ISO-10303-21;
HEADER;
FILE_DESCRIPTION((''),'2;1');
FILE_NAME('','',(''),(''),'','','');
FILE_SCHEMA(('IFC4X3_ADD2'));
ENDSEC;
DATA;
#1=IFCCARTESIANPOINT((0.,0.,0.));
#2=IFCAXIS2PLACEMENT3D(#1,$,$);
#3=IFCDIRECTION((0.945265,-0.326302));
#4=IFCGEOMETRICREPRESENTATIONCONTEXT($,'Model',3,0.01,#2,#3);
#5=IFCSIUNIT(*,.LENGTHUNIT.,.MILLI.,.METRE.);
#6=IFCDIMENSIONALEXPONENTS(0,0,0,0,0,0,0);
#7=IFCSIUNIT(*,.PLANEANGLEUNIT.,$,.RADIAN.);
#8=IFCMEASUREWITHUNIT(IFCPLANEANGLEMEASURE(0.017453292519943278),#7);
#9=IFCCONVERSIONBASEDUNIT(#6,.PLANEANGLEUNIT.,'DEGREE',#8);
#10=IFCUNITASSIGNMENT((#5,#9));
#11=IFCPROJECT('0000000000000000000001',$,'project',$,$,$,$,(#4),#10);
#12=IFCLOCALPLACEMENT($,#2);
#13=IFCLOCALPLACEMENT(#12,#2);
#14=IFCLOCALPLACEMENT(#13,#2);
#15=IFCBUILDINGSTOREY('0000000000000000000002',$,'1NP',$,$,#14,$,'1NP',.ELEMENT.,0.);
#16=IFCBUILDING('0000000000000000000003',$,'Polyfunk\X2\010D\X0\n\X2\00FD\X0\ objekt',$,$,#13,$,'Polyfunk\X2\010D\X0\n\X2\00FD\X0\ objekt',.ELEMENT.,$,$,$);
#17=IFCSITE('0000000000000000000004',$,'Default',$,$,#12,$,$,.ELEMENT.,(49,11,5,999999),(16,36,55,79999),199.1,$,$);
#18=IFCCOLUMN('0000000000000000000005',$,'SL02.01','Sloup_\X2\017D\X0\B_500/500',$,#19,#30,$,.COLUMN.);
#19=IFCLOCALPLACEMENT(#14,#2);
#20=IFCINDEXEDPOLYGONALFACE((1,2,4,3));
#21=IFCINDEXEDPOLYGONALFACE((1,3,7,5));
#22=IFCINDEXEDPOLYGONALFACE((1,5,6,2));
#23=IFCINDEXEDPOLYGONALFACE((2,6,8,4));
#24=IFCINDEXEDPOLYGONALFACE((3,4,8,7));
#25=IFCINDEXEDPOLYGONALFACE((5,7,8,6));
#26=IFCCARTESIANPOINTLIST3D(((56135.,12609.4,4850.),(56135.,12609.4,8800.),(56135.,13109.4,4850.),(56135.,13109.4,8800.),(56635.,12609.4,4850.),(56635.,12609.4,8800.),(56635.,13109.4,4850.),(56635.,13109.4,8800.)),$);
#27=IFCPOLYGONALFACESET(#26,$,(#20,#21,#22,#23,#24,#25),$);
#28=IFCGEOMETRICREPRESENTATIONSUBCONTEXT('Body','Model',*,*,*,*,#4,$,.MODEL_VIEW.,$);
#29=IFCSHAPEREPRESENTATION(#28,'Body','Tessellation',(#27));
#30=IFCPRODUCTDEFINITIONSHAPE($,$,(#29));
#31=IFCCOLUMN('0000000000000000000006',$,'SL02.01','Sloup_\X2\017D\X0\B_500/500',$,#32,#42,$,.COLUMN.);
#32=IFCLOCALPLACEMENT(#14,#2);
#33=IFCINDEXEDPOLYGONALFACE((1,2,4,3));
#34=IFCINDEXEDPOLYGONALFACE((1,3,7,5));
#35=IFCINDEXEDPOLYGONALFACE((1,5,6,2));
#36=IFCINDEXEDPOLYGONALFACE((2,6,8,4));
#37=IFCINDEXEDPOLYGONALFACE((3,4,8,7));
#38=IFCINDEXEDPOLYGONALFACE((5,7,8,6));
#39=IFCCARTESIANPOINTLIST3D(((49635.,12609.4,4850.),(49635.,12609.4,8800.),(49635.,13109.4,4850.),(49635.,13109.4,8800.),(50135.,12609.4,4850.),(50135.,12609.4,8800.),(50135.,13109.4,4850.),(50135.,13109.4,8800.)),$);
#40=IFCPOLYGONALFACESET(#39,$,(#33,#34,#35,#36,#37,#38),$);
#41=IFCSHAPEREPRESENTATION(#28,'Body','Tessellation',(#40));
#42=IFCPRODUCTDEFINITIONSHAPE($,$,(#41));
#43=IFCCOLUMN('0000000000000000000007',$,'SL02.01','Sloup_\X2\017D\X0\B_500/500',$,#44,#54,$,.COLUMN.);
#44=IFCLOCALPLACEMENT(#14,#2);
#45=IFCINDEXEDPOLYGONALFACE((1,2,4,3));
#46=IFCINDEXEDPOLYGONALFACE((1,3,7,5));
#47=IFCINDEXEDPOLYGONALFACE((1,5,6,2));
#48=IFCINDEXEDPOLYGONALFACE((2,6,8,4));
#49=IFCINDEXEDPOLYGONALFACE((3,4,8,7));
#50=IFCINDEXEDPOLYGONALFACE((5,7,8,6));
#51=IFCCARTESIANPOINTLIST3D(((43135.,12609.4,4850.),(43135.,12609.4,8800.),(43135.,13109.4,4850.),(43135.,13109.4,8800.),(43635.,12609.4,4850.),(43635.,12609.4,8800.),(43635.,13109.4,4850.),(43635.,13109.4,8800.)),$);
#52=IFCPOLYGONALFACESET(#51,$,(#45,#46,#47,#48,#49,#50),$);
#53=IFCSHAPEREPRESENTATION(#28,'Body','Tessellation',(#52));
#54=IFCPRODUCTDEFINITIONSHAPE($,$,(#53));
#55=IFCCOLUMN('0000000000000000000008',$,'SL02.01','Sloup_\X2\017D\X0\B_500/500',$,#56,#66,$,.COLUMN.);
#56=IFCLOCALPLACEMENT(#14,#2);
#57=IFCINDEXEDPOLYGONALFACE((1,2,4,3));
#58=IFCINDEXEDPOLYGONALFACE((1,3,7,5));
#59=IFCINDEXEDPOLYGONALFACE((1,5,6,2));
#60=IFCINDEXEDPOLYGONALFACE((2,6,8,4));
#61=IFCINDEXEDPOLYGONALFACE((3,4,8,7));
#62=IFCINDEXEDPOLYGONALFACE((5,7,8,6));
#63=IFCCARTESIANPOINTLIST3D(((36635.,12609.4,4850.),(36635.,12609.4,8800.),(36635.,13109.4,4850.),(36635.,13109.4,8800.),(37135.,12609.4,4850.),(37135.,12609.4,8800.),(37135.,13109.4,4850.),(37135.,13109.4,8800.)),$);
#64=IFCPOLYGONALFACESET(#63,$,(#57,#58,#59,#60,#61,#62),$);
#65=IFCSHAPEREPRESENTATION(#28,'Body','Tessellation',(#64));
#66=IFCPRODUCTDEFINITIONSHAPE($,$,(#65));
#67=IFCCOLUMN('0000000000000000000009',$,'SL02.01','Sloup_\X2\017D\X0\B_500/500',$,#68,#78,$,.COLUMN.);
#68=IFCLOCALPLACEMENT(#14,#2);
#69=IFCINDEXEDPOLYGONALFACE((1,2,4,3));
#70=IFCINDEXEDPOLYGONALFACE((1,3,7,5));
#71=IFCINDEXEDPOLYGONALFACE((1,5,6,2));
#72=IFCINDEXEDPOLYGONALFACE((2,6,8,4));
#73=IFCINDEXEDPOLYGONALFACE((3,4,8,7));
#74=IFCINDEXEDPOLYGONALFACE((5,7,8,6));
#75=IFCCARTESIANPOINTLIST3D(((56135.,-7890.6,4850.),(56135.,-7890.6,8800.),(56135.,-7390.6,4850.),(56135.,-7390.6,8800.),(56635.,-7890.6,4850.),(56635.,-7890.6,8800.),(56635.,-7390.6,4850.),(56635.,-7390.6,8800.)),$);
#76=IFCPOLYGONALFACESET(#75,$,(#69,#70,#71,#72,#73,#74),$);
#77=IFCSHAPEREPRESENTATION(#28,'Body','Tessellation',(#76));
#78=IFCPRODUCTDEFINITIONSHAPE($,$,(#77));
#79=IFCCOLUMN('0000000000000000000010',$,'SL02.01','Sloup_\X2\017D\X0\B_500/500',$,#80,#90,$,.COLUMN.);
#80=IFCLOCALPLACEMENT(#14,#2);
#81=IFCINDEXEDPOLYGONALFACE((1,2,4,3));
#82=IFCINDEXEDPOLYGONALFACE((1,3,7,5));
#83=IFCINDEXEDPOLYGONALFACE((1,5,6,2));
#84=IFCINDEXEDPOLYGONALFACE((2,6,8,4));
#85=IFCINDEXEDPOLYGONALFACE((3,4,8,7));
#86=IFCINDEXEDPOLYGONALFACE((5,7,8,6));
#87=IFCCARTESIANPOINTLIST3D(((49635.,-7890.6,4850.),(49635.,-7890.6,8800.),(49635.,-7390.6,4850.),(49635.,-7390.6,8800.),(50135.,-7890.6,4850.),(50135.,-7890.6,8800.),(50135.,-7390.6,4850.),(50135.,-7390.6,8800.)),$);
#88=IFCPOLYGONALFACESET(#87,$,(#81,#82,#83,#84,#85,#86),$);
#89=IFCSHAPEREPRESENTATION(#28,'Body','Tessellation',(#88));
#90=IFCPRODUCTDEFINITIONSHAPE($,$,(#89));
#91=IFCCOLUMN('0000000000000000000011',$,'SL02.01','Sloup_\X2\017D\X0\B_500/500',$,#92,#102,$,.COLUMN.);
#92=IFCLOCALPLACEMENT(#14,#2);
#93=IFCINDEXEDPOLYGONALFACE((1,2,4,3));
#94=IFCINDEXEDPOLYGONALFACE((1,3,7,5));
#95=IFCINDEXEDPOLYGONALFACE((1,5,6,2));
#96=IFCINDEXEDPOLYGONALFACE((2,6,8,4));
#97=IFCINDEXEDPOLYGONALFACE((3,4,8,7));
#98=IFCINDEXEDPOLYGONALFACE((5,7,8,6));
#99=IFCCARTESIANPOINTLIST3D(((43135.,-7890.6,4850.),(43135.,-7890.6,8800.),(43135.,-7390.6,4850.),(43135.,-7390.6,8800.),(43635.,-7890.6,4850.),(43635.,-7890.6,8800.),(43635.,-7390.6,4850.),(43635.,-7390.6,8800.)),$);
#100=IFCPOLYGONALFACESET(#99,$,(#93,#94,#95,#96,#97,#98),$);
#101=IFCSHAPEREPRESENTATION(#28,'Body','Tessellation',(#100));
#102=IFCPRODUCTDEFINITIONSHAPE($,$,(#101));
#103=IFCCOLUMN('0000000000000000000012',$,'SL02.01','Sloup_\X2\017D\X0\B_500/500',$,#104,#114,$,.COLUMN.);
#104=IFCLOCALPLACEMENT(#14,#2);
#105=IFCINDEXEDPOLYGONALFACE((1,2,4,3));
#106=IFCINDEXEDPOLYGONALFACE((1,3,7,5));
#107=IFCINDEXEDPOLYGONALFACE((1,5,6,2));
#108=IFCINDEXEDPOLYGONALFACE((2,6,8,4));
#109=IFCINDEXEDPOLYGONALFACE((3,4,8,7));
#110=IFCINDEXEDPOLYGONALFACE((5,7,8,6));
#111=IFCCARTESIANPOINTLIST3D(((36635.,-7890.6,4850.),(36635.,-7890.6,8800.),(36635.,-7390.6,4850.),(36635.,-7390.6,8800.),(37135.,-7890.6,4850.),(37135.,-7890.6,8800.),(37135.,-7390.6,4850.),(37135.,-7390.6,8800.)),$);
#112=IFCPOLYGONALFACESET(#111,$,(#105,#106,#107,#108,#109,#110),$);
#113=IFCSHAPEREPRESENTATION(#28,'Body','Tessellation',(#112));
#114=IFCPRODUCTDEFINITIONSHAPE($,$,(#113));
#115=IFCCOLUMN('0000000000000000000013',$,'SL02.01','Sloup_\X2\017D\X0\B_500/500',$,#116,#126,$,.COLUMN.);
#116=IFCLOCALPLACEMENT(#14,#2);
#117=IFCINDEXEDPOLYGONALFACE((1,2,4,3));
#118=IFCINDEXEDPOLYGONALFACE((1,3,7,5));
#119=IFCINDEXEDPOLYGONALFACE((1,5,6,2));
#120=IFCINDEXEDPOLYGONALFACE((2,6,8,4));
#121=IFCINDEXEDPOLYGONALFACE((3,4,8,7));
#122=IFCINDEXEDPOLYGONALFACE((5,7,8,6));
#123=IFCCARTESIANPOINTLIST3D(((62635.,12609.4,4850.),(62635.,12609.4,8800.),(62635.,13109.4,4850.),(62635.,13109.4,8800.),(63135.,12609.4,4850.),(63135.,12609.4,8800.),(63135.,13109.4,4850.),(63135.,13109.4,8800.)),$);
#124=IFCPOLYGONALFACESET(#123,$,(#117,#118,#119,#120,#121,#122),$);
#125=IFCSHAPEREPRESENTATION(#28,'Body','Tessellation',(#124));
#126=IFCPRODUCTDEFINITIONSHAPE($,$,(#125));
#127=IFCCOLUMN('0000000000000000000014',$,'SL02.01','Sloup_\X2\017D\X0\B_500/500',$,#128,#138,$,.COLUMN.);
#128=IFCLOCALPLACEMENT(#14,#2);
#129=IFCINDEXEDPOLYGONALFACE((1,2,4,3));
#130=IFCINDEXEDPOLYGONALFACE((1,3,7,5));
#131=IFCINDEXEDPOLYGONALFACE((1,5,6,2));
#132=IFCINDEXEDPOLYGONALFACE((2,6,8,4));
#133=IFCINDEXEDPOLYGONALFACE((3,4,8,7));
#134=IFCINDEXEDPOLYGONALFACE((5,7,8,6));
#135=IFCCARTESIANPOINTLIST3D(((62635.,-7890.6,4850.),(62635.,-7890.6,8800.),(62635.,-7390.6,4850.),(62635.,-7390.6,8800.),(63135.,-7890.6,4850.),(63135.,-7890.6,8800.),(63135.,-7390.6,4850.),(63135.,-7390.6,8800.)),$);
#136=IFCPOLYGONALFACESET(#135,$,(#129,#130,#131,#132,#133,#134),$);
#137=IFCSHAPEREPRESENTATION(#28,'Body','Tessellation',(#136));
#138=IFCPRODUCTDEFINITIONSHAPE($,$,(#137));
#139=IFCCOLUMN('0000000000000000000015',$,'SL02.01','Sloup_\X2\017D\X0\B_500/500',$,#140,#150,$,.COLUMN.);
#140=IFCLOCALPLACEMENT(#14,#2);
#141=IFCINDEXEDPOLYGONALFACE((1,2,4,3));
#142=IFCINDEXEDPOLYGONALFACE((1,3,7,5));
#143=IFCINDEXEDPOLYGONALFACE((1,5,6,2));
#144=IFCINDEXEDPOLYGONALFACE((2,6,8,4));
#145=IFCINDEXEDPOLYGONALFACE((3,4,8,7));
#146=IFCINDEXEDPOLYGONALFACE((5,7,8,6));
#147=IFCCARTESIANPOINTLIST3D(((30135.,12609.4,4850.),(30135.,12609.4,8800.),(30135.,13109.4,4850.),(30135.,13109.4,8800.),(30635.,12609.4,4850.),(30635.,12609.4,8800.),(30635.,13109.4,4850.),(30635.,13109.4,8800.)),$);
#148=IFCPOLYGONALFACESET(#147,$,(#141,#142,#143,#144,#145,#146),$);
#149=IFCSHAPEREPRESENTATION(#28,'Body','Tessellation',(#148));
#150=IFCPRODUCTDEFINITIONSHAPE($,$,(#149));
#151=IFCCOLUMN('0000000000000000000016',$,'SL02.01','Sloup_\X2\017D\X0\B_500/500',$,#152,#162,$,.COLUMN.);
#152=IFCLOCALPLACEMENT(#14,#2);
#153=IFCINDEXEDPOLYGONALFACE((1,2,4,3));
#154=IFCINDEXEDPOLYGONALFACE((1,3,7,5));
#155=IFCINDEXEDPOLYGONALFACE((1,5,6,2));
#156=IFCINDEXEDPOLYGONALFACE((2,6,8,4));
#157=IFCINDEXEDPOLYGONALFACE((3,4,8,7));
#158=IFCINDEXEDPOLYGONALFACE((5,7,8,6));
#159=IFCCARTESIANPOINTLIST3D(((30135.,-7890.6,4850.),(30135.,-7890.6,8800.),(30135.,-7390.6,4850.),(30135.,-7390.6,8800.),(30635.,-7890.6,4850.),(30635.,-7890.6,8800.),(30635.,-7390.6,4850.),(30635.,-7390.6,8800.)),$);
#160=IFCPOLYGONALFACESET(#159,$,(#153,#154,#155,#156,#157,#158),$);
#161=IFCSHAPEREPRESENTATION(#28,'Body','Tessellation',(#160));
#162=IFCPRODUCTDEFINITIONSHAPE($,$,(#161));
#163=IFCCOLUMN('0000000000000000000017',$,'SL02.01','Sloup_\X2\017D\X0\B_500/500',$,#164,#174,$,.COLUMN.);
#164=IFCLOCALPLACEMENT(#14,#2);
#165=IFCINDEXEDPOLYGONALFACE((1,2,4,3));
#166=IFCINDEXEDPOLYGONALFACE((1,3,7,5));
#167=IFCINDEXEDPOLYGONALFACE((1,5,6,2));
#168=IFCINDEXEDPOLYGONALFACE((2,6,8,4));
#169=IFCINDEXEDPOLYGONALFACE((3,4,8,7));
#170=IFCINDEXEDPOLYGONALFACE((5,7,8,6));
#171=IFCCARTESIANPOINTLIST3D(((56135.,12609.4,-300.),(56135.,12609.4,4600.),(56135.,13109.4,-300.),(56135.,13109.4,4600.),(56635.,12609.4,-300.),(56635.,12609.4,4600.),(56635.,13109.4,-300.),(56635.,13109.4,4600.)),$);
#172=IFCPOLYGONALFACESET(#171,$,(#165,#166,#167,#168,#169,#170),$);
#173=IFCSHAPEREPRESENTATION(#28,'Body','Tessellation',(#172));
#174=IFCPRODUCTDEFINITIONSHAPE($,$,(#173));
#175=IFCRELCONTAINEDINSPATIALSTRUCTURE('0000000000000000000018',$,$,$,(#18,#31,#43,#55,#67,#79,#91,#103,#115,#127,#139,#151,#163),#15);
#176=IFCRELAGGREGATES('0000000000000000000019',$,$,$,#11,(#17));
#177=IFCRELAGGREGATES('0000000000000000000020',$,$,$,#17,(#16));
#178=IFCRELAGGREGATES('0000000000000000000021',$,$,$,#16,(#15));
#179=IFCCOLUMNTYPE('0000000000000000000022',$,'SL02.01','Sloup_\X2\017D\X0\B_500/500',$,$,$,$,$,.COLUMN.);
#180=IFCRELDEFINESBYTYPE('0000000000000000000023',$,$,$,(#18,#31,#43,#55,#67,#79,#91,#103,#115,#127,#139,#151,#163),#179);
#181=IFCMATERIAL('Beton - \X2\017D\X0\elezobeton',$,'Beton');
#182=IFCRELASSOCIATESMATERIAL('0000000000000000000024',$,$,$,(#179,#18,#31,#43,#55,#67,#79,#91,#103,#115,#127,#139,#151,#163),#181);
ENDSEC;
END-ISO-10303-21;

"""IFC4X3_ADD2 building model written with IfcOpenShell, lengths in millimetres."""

from ifc_helpers import new_model, entity, si_unit, converted_unit, direction, frame, frame_2d, origin, origin_2d_with_axis, place, context, subcontext, project, spatial, rectangle, extrude, source, transform, mapped, material, material_profile, profile_set, profile_usage, type_object, element, save


model = new_model("IFC4X3_ADD2")

# Units and contexts
model_context = context("Model", 3, precision=0.01, world=origin(), true_north=direction((0.945265, -0.326302)))
body_context = subcontext(model_context, "Body", "Model", "MODEL_VIEW")
ifc_project = project(units=[si_unit("LENGTHUNIT", "METRE", prefix="MILLI"), converted_unit("PLANEANGLEUNIT", "DEGREE", entity("IfcPlaneAngleMeasure", 0.017453292519943278), si_unit("PLANEANGLEUNIT", "RADIAN"), dimensions=[0, 0, 0, 0, 0, 0, 0])], contexts=[model_context])

# Site, building, storey
site_placement = place(None, origin())
site = spatial("IfcSite", under=ifc_project, at=site_placement, Name="Default", CompositionType="ELEMENT", RefLatitude=(49, 11, 5, 999999), RefLongitude=(16, 36, 55, 79999), RefElevation=199.1)
building_placement = place(site_placement, origin())
building = spatial("IfcBuilding", under=site, at=building_placement, Name="Polyfunkčný objekt", LongName="Polyfunkčný objekt", CompositionType="ELEMENT")
storey_placement = place(building_placement, origin())
storey = spatial("IfcBuildingStorey", under=building, at=storey_placement, Name="1NP", LongName="1NP", CompositionType="ELEMENT", Elevation=0.0)

# Columns
ifc_material = material(Name="Beton - Železobeton", Category="Beton")
ifc_material_profile_1 = material_profile(ifc_material, rectangle(XDim=500.0, YDim=500.0, at=frame_2d((0.0, 0.0), x_axis=(1.0, 0.0))), Name="Sloup_ŽB_500/500")
ifc_profile_set_1 = profile_set([ifc_material_profile_1], Name="Sloup_ŽB_500/500")
ifc_profile_usage_1 = profile_usage(ifc_profile_set_1)
column_type_1 = type_object("IfcColumnType", Name="SL02.01", Description="Sloup_ŽB_500/500", PredefinedType="COLUMN", material=ifc_profile_set_1)
shared_shape_1 = source(origin(), body_context, "Body", "SweptSolid", [
    extrude(rectangle(XDim=500.0, YDim=500.0, at=frame_2d((0.0, 0.0), x_axis=(1.0, 0.0))), frame((56385.0, 12859.4, 4850.0)), (0.0, 0.0, 1.0), 3950.0),
])
column_1_placement = place(storey_placement, origin())
element("IfcColumn", 1, at=column_1_placement, inside=storey, type_object=column_type_1, material=ifc_profile_usage_1, Name="SL02.01", Description="Sloup_ŽB_500/500", PredefinedType="COLUMN", context=body_context, shape_type="MappedRepresentation", body=[
    mapped(shared_shape_1, transform((0.0, 0.0, 0.0), scale=1.0)),
])
shared_shape_2 = source(origin(), body_context, "Body", "SweptSolid", [
    extrude(rectangle(XDim=500.0, YDim=500.0, at=origin_2d_with_axis()), frame((49885.0, 12859.4, 4850.0)), (0.0, 0.0, 1.0), 3950.0),
])
column_2_placement = place(storey_placement, origin())
element("IfcColumn", 2, at=column_2_placement, inside=storey, type_object=column_type_1, material=ifc_profile_usage_1, Name="SL02.01", Description="Sloup_ŽB_500/500", PredefinedType="COLUMN", context=body_context, shape_type="MappedRepresentation", body=[
    mapped(shared_shape_2, transform((0.0, 0.0, 0.0), scale=1.0)),
])
shared_shape_3 = source(origin(), body_context, "Body", "SweptSolid", [
    extrude(rectangle(XDim=500.0, YDim=500.0, at=origin_2d_with_axis()), frame((43385.0, 12859.4, 4850.0)), (0.0, 0.0, 1.0), 3950.0),
])
column_3_placement = place(storey_placement, origin())
element("IfcColumn", 3, at=column_3_placement, inside=storey, type_object=column_type_1, material=ifc_profile_usage_1, Name="SL02.01", Description="Sloup_ŽB_500/500", PredefinedType="COLUMN", context=body_context, shape_type="MappedRepresentation", body=[
    mapped(shared_shape_3, transform((0.0, 0.0, 0.0), scale=1.0)),
])
shared_shape_4 = source(origin(), body_context, "Body", "SweptSolid", [
    extrude(rectangle(XDim=500.0, YDim=500.0, at=origin_2d_with_axis()), frame((36885.0, 12859.4, 4850.0), z_axis=(0.0, 0.0, 1.0), x_axis=(0.0, 1.0, 0.0)), (0.0, 0.0, 1.0), 3950.0),
])
column_4_placement = place(storey_placement, origin())
element("IfcColumn", 4, at=column_4_placement, inside=storey, type_object=column_type_1, material=ifc_profile_usage_1, Name="SL02.01", Description="Sloup_ŽB_500/500", PredefinedType="COLUMN", context=body_context, shape_type="MappedRepresentation", body=[
    mapped(shared_shape_4, transform((0.0, 0.0, 0.0), scale=1.0)),
])
shared_shape_5 = source(origin(), body_context, "Body", "SweptSolid", [
    extrude(rectangle(XDim=500.0, YDim=500.0, at=origin_2d_with_axis()), frame((56385.0, -7640.6, 4850.0)), (0.0, 0.0, 1.0), 3950.0),
])
column_5_placement = place(storey_placement, origin())
element("IfcColumn", 5, at=column_5_placement, inside=storey, type_object=column_type_1, material=ifc_profile_usage_1, Name="SL02.01", Description="Sloup_ŽB_500/500", PredefinedType="COLUMN", context=body_context, shape_type="MappedRepresentation", body=[
    mapped(shared_shape_5, transform((0.0, 0.0, 0.0), scale=1.0)),
])
shared_shape_6 = source(origin(), body_context, "Body", "SweptSolid", [
    extrude(rectangle(XDim=500.0, YDim=500.0, at=frame_2d((0.0, 0.0), x_axis=(1.0, 0.0))), frame((49885.0, -7640.6, 4850.0)), (0.0, 0.0, 1.0), 3950.0),
])
column_6_placement = place(storey_placement, origin())
element("IfcColumn", 6, at=column_6_placement, inside=storey, type_object=column_type_1, material=ifc_profile_usage_1, Name="SL02.01", Description="Sloup_ŽB_500/500", PredefinedType="COLUMN", context=body_context, shape_type="MappedRepresentation", body=[
    mapped(shared_shape_6, transform((0.0, 0.0, 0.0), scale=1.0)),
])
shared_shape_7 = source(origin(), body_context, "Body", "SweptSolid", [
    extrude(rectangle(XDim=500.0, YDim=500.0, at=origin_2d_with_axis()), frame((43385.0, -7640.6, 4850.0)), (0.0, 0.0, 1.0), 3950.0),
])
column_7_placement = place(storey_placement, origin())
element("IfcColumn", 7, at=column_7_placement, inside=storey, type_object=column_type_1, material=ifc_profile_usage_1, Name="SL02.01", Description="Sloup_ŽB_500/500", PredefinedType="COLUMN", context=body_context, shape_type="MappedRepresentation", body=[
    mapped(shared_shape_7, transform((0.0, 0.0, 0.0), scale=1.0)),
])
shared_shape_8 = source(origin(), body_context, "Body", "SweptSolid", [
    extrude(rectangle(XDim=500.0, YDim=500.0, at=origin_2d_with_axis()), frame((36885.0, -7640.6, 4850.0)), (0.0, 0.0, 1.0), 3950.0),
])
column_8_placement = place(storey_placement, origin())
element("IfcColumn", 8, at=column_8_placement, inside=storey, type_object=column_type_1, material=ifc_profile_usage_1, Name="SL02.01", Description="Sloup_ŽB_500/500", PredefinedType="COLUMN", context=body_context, shape_type="MappedRepresentation", body=[
    mapped(shared_shape_8, transform((0.0, 0.0, 0.0), scale=1.0)),
])
shared_shape_9 = source(origin(), body_context, "Body", "SweptSolid", [
    extrude(rectangle(XDim=500.0, YDim=500.0, at=origin_2d_with_axis()), frame((62885.0, 12859.4, 4850.0), z_axis=(0.0, 0.0, 1.0), x_axis=(-1.0, 0.0, 0.0)), (0.0, 0.0, 1.0), 3950.0),
])
column_9_placement = place(storey_placement, origin())
element("IfcColumn", 9, at=column_9_placement, inside=storey, type_object=column_type_1, material=ifc_profile_usage_1, Name="SL02.01", Description="Sloup_ŽB_500/500", PredefinedType="COLUMN", context=body_context, shape_type="MappedRepresentation", body=[
    mapped(shared_shape_9, transform((0.0, 0.0, 0.0), scale=1.0)),
])
shared_shape_10 = source(origin(), body_context, "Body", "SweptSolid", [
    extrude(rectangle(XDim=500.0, YDim=500.0, at=frame_2d((0.0, 0.0), x_axis=(1.0, 0.0))), frame((62885.0, -7640.6, 4850.0), z_axis=(0.0, 0.0, 1.0), x_axis=(-1.0, 0.0, 0.0)), (0.0, 0.0, 1.0), 3950.0),
])
column_10_placement = place(storey_placement, origin())
element("IfcColumn", 10, at=column_10_placement, inside=storey, type_object=column_type_1, material=ifc_profile_usage_1, Name="SL02.01", Description="Sloup_ŽB_500/500", PredefinedType="COLUMN", context=body_context, shape_type="MappedRepresentation", body=[
    mapped(shared_shape_10, transform((0.0, 0.0, 0.0), scale=1.0)),
])
shared_shape_11 = source(origin(), body_context, "Body", "SweptSolid", [
    extrude(rectangle(XDim=500.0, YDim=500.0, at=origin_2d_with_axis()), frame((30385.0, 12859.4, 4850.0), z_axis=(0.0, 0.0, 1.0), x_axis=(-1.0, 0.0, 0.0)), (0.0, 0.0, 1.0), 3950.0),
])
column_11_placement = place(storey_placement, origin())
element("IfcColumn", 11, at=column_11_placement, inside=storey, type_object=column_type_1, material=ifc_profile_usage_1, Name="SL02.01", Description="Sloup_ŽB_500/500", PredefinedType="COLUMN", context=body_context, shape_type="MappedRepresentation", body=[
    mapped(shared_shape_11, transform((0.0, 0.0, 0.0), scale=1.0)),
])
shared_shape_12 = source(origin(), body_context, "Body", "SweptSolid", [
    extrude(rectangle(XDim=500.0, YDim=500.0, at=frame_2d((0.0, 0.0), x_axis=(1.0, 0.0))), frame((30385.0, -7640.6, 4850.0), z_axis=(0.0, 0.0, 1.0), x_axis=(-1.0, 0.0, 0.0)), (0.0, 0.0, 1.0), 3950.0),
])
column_12_placement = place(storey_placement, origin())
element("IfcColumn", 12, at=column_12_placement, inside=storey, type_object=column_type_1, material=ifc_profile_usage_1, Name="SL02.01", Description="Sloup_ŽB_500/500", PredefinedType="COLUMN", context=body_context, shape_type="MappedRepresentation", body=[
    mapped(shared_shape_12, transform((0.0, 0.0, 0.0), scale=1.0)),
])
shared_shape_13 = source(origin(), body_context, "Body", "SweptSolid", [
    extrude(rectangle(XDim=500.0, YDim=500.0, at=frame_2d((0.0, 83.3), x_axis=(1.0, 0.0))), frame((56385.0, 12776.1, -300.0)), (0.0, 0.0, 1.0), 4900.0),
])
column_13_placement = place(storey_placement, origin())
element("IfcColumn", 13, at=column_13_placement, inside=storey, type_object=column_type_1, material=ifc_profile_usage_1, Name="SL02.01", Description="Sloup_ŽB_500/500", PredefinedType="COLUMN", context=body_context, shape_type="MappedRepresentation", body=[
    mapped(shared_shape_13, transform((0.0, 0.0, 0.0), scale=1.0)),
])

save(model, "model.ifc")
